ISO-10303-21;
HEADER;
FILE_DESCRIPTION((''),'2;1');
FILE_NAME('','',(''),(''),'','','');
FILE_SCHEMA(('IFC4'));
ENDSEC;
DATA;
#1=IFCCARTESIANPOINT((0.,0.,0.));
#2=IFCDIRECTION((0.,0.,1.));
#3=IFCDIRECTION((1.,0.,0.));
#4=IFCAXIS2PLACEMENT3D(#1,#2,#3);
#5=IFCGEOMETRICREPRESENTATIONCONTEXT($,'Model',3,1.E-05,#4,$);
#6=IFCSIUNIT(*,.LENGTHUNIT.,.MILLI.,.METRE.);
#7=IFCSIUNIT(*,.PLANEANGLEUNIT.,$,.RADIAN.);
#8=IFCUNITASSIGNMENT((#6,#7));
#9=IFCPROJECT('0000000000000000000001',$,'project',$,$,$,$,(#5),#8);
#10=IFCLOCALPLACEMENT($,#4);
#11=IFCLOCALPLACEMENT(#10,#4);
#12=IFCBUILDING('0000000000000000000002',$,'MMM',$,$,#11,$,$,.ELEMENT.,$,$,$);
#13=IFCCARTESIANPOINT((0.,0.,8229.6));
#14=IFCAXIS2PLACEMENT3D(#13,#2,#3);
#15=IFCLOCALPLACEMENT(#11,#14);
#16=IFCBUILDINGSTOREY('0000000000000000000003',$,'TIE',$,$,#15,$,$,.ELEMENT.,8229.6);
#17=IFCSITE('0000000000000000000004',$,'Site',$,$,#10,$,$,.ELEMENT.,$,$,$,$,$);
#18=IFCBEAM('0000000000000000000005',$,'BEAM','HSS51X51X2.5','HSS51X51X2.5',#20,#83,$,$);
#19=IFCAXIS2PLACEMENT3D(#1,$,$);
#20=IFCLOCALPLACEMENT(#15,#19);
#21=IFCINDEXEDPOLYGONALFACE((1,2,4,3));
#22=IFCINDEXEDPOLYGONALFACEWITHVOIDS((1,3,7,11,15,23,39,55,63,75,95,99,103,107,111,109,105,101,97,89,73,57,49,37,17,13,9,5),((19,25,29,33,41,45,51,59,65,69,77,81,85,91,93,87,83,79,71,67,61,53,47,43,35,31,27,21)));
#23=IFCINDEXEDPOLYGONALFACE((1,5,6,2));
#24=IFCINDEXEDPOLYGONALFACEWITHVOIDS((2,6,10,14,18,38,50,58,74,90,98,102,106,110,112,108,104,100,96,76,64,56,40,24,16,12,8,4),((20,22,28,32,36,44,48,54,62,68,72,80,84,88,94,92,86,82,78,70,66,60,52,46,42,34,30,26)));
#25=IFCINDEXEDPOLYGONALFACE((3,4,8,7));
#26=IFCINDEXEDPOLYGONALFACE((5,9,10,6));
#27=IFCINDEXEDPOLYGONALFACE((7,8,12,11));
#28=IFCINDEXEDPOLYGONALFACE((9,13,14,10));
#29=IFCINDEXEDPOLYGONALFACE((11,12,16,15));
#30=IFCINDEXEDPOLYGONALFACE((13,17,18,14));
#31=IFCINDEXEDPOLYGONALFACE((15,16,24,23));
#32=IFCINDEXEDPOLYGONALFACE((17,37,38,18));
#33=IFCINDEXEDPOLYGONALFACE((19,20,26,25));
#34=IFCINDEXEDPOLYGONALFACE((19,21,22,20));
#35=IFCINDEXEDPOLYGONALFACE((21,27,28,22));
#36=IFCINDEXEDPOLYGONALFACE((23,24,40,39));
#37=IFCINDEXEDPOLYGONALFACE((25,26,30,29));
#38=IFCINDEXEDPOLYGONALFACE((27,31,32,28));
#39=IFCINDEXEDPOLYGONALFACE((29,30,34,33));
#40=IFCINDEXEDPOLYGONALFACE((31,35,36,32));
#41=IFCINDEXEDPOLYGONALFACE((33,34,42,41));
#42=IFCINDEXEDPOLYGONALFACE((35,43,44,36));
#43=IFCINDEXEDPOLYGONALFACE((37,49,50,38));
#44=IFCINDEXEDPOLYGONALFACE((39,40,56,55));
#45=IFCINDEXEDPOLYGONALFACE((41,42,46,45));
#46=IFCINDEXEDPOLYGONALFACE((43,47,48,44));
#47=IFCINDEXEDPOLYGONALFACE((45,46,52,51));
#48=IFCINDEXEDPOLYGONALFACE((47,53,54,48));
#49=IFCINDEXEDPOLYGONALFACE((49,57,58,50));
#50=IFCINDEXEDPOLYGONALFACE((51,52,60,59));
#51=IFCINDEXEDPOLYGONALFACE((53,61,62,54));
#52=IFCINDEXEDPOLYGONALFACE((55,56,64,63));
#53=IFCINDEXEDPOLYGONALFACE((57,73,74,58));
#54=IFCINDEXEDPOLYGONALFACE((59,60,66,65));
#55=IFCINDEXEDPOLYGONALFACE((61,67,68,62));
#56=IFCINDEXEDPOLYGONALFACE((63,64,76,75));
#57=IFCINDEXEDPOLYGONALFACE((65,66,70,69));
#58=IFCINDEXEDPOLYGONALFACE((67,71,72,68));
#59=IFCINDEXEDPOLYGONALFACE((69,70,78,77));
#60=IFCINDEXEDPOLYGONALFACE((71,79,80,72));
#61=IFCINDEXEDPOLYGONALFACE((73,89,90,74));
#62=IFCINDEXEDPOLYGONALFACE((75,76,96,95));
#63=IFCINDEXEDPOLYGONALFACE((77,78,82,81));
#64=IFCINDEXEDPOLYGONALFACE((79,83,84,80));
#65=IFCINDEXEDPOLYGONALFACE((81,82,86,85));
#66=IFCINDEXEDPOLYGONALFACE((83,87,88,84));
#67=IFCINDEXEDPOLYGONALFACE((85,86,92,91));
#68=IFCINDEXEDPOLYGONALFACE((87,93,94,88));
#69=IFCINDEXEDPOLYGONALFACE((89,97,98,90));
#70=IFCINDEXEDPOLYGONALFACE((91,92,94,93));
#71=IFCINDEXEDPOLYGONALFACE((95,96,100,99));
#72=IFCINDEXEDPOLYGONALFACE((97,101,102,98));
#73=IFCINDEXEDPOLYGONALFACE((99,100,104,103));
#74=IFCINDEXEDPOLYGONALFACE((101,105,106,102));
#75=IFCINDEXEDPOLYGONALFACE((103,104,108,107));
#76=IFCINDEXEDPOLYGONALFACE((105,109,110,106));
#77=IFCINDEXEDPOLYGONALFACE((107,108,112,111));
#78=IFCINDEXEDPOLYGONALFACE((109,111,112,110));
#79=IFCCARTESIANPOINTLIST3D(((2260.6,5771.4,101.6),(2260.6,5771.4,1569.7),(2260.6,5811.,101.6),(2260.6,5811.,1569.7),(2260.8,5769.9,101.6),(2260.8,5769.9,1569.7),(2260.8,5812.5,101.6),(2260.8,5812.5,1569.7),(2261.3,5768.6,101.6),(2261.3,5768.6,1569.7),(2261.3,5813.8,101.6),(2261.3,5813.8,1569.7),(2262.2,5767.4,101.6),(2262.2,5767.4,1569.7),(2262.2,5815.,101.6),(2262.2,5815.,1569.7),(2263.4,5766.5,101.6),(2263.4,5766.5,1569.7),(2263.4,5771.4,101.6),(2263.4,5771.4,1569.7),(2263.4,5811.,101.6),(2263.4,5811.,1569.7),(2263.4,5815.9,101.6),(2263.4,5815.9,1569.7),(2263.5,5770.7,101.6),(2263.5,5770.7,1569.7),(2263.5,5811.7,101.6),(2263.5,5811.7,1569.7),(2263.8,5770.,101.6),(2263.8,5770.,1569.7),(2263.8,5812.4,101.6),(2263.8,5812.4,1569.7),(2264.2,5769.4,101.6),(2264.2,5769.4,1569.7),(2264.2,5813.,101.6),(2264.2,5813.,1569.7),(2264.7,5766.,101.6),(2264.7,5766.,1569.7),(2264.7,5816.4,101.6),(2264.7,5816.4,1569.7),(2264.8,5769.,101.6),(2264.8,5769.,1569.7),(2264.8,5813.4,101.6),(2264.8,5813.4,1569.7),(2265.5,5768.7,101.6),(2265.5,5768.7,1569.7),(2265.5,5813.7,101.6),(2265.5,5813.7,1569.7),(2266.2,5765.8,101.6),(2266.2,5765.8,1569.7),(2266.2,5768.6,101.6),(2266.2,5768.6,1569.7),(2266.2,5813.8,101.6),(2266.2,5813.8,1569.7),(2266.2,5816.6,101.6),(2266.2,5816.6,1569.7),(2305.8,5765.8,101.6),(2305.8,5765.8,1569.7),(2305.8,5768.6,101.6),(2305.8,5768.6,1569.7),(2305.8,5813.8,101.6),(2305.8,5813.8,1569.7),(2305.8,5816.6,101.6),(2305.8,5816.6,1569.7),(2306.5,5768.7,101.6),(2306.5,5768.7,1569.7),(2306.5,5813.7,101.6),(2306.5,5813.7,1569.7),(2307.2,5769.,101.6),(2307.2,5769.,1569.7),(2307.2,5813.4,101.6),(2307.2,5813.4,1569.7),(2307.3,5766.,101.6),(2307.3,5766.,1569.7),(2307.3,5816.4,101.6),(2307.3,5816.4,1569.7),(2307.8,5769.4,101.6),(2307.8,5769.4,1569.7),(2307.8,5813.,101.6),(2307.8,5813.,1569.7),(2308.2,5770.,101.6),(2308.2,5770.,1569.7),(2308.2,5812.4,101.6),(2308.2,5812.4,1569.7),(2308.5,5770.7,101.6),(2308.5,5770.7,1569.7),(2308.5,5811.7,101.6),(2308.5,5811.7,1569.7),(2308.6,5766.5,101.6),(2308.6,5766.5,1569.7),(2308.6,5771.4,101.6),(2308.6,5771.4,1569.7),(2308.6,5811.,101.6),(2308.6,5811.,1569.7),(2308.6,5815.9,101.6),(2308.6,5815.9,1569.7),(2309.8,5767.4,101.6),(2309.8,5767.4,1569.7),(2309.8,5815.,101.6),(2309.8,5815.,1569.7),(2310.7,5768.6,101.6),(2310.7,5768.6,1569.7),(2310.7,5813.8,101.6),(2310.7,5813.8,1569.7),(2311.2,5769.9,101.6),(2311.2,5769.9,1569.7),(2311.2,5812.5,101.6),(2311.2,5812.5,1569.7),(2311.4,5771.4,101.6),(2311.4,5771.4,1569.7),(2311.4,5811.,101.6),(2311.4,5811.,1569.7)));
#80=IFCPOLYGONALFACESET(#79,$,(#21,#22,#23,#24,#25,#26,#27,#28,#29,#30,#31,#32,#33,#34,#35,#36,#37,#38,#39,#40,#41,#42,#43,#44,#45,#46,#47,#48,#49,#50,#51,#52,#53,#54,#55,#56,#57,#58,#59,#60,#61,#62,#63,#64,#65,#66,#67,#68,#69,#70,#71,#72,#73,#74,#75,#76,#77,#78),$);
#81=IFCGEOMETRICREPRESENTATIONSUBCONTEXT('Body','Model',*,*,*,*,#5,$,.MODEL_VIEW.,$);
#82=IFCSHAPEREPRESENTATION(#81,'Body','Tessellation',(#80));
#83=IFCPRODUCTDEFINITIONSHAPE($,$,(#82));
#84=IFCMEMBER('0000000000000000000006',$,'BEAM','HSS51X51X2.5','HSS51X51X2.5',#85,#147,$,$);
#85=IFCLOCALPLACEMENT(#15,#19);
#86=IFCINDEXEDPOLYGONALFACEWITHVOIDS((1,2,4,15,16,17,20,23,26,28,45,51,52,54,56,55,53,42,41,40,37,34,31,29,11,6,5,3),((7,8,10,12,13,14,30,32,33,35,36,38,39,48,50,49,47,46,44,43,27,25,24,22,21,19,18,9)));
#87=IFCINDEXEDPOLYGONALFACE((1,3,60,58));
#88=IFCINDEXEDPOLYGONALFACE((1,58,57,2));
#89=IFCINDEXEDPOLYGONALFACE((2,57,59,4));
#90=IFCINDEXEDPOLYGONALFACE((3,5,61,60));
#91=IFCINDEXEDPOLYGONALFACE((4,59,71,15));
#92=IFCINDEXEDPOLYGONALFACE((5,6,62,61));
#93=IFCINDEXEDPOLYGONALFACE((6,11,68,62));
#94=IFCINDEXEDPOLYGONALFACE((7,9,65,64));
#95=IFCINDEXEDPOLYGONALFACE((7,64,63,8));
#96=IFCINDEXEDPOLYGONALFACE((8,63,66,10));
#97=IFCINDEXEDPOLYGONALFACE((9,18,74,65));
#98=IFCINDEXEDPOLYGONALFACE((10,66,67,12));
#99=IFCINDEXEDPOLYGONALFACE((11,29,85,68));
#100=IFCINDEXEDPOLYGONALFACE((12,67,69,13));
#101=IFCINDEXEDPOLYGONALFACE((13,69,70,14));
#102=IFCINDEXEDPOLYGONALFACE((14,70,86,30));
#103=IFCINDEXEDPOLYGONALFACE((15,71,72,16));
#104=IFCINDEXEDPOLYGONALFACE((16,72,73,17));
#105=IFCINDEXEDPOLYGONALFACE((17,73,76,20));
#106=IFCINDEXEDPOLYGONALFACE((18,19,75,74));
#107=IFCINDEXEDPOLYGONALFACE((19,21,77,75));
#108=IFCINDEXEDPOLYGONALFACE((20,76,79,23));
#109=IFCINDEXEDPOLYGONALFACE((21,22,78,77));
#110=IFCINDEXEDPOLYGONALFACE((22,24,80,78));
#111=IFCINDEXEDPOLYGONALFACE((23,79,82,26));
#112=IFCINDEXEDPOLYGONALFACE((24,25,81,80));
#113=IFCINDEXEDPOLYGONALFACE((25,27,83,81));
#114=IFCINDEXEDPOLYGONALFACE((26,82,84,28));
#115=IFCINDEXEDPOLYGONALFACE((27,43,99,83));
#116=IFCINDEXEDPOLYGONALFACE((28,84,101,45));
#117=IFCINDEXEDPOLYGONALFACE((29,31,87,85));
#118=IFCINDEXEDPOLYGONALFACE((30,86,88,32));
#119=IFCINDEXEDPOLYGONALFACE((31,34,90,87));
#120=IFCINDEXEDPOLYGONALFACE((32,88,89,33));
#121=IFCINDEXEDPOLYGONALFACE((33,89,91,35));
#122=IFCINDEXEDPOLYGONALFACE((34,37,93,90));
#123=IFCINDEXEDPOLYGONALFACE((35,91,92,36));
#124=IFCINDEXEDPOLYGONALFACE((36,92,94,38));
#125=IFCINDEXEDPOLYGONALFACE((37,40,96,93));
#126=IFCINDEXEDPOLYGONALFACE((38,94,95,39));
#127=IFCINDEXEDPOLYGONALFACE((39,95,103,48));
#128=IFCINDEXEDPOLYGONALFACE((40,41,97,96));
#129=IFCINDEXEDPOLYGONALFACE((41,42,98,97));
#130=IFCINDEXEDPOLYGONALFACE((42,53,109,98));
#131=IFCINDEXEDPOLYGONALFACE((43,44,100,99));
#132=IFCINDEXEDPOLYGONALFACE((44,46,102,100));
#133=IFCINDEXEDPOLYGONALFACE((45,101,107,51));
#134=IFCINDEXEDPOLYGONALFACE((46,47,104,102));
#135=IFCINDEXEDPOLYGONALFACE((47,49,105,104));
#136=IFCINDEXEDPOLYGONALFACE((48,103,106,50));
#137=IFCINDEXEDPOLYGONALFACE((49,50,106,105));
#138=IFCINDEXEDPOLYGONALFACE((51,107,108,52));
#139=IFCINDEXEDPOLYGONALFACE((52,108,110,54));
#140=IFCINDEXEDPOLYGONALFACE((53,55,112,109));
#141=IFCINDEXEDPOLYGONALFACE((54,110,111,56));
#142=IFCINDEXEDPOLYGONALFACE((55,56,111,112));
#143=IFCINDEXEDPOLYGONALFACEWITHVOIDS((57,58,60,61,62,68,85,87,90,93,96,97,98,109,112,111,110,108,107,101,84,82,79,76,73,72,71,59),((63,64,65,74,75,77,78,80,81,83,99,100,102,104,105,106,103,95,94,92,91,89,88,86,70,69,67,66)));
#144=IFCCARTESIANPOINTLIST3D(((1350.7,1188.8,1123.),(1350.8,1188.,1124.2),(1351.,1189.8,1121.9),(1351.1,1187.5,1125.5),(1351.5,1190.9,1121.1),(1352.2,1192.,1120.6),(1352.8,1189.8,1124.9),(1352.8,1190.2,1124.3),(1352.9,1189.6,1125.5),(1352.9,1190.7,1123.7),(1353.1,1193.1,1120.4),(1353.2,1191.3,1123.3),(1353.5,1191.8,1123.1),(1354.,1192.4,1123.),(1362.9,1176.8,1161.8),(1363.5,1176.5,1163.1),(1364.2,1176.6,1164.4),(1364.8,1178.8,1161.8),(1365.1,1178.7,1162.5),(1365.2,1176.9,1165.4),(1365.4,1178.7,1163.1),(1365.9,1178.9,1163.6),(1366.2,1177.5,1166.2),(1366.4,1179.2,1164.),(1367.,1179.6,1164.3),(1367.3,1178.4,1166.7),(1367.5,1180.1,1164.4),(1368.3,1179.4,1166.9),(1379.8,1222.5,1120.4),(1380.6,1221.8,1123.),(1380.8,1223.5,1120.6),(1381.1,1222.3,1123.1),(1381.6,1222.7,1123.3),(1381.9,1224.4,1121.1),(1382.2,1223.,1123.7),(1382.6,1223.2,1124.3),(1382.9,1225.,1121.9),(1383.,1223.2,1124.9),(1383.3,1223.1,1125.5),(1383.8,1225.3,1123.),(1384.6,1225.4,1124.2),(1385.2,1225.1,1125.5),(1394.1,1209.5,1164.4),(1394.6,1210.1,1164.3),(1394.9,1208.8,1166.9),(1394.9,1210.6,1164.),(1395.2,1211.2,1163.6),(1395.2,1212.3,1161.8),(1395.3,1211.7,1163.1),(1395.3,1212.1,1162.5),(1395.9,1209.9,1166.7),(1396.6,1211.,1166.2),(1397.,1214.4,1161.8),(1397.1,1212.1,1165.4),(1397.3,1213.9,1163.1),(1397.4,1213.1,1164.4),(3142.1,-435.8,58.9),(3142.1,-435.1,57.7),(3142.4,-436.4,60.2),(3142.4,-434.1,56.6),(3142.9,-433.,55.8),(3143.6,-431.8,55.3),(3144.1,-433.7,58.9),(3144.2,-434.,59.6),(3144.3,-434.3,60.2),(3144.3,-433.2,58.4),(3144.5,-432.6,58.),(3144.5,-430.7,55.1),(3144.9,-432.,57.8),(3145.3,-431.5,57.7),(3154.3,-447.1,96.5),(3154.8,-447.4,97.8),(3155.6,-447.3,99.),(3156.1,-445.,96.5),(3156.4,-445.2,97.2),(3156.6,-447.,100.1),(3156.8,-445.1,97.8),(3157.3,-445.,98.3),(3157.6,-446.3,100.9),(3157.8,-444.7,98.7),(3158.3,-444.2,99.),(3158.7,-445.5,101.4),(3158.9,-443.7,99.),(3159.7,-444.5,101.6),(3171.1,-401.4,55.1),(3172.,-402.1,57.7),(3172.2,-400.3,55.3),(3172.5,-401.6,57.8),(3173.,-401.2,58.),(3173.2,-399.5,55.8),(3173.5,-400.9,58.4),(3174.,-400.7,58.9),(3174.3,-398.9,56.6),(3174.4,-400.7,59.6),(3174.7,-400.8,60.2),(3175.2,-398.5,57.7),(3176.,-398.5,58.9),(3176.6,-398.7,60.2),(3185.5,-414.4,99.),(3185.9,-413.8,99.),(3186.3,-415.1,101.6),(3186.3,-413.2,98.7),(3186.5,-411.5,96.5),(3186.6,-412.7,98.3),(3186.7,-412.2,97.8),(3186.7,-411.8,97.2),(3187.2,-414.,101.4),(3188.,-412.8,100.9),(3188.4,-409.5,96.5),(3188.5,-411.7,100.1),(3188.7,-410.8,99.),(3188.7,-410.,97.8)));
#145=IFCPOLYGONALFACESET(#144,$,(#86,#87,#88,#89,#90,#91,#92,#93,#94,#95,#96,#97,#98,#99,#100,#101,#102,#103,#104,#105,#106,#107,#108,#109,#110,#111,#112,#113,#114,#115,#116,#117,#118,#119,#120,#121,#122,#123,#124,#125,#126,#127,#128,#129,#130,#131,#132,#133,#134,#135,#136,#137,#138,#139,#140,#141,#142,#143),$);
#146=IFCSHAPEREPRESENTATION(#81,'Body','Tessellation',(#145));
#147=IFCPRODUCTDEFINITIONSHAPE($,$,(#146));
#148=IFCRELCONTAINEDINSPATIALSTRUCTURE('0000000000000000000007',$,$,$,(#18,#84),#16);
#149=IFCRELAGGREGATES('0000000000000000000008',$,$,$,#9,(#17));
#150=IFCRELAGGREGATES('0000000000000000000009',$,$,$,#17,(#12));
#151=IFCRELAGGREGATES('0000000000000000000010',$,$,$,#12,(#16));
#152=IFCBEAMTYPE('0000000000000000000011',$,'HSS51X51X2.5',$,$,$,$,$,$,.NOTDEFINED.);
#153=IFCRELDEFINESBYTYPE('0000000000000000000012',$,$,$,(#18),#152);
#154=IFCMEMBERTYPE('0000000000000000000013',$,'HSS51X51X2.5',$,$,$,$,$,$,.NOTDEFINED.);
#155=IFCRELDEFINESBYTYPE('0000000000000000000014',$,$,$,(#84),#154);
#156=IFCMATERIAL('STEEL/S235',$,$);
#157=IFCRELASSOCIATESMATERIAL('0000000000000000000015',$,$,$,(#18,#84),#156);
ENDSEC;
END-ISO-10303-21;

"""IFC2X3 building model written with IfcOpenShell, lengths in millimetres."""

from ifc_helpers import new_model, si_unit, frame, origin_with_axes, origin_2d_with_axis, place, context, subcontext, project, spatial, hollow_rectangle, extrude, material, type_object, element, save


model = new_model("IFC2X3")

# Units and contexts
model_context = context("Model", 3, precision=1e-05, world=origin_with_axes())
body_context = subcontext(model_context, "Body", "Model", "MODEL_VIEW")
ifc_project = project(units=[si_unit("LENGTHUNIT", "METRE", prefix="MILLI"), si_unit("PLANEANGLEUNIT", "RADIAN")], contexts=[model_context])

# Site, building, storey
site_placement = place(None, origin_with_axes())
site = spatial("IfcSite", under=ifc_project, at=site_placement, Name="Site", CompositionType="ELEMENT")
building_placement = place(site_placement, origin_with_axes())
building = spatial("IfcBuilding", under=site, at=building_placement, Name="MMM", CompositionType="ELEMENT")
storey_placement = place(building_placement, frame((0.0, 0.0, 8229.6), z_axis=(0.0, 0.0, 1.0), x_axis=(1.0, 0.0, 0.0)))
storey = spatial("IfcBuildingStorey", under=building, at=storey_placement, Name="TIE", CompositionType="ELEMENT", Elevation=8229.6)

# Beam
ifc_material = material(Name="STEEL/S235")
beam_type_1 = type_object("IfcBeamType", Name="HSS51X51X2.5", PredefinedType="NOTDEFINED")
beam_1_placement = place(storey_placement, frame((2286.0, 5791.2, 1569.7), z_axis=(1.0, 0.0, 0.0), x_axis=(0.0, 0.0, -1.0)))
element("IfcBeam", 1, at=beam_1_placement, inside=storey, type_object=beam_type_1, material=ifc_material, Name="BEAM", Description="HSS51X51X2.5", ObjectType="HSS51X51X2.5", context=body_context, shape_type="SweptSolid", body=[
    extrude(hollow_rectangle(XDim=50.8, YDim=50.8, WallThickness=2.8, InnerFilletRadius=2.8, OuterFilletRadius=5.6, at=origin_2d_with_axis()), frame((1468.1, 0.0, 0.0), z_axis=(-1.0, 0.0, 0.0), x_axis=(0.0, -1.0, 0.0)), (0.0, 0.0, 1.0), 1468.1),
])

# Member
member_type_1 = type_object("IfcMemberType", Name="HSS51X51X2.5", PredefinedType="NOTDEFINED")
member_1_placement = place(storey_placement, frame((1374.0, 1200.9, 1143.7), z_axis=(0.298731, -0.270799, 0.915111), x_axis=(0.678002, -0.614607, -0.403203)))
element("IfcMember", 2, at=member_1_placement, inside=storey, type_object=member_type_1, material=ifc_material, Name="BEAM", Description="HSS51X51X2.5", ObjectType="HSS51X51X2.5", context=body_context, shape_type="SweptSolid", body=[
    extrude(hollow_rectangle(XDim=50.8, YDim=50.8, WallThickness=2.8, InnerFilletRadius=2.8, OuterFilletRadius=5.6, at=origin_2d_with_axis()), frame((2642.1, 0.0, 0.0), z_axis=(-1.0, 0.0, 0.0), x_axis=(0.0, -1.0, 0.0)), (0.0, 0.0, 1.0), 2642.1),
])

save(model, "model.ifc")
